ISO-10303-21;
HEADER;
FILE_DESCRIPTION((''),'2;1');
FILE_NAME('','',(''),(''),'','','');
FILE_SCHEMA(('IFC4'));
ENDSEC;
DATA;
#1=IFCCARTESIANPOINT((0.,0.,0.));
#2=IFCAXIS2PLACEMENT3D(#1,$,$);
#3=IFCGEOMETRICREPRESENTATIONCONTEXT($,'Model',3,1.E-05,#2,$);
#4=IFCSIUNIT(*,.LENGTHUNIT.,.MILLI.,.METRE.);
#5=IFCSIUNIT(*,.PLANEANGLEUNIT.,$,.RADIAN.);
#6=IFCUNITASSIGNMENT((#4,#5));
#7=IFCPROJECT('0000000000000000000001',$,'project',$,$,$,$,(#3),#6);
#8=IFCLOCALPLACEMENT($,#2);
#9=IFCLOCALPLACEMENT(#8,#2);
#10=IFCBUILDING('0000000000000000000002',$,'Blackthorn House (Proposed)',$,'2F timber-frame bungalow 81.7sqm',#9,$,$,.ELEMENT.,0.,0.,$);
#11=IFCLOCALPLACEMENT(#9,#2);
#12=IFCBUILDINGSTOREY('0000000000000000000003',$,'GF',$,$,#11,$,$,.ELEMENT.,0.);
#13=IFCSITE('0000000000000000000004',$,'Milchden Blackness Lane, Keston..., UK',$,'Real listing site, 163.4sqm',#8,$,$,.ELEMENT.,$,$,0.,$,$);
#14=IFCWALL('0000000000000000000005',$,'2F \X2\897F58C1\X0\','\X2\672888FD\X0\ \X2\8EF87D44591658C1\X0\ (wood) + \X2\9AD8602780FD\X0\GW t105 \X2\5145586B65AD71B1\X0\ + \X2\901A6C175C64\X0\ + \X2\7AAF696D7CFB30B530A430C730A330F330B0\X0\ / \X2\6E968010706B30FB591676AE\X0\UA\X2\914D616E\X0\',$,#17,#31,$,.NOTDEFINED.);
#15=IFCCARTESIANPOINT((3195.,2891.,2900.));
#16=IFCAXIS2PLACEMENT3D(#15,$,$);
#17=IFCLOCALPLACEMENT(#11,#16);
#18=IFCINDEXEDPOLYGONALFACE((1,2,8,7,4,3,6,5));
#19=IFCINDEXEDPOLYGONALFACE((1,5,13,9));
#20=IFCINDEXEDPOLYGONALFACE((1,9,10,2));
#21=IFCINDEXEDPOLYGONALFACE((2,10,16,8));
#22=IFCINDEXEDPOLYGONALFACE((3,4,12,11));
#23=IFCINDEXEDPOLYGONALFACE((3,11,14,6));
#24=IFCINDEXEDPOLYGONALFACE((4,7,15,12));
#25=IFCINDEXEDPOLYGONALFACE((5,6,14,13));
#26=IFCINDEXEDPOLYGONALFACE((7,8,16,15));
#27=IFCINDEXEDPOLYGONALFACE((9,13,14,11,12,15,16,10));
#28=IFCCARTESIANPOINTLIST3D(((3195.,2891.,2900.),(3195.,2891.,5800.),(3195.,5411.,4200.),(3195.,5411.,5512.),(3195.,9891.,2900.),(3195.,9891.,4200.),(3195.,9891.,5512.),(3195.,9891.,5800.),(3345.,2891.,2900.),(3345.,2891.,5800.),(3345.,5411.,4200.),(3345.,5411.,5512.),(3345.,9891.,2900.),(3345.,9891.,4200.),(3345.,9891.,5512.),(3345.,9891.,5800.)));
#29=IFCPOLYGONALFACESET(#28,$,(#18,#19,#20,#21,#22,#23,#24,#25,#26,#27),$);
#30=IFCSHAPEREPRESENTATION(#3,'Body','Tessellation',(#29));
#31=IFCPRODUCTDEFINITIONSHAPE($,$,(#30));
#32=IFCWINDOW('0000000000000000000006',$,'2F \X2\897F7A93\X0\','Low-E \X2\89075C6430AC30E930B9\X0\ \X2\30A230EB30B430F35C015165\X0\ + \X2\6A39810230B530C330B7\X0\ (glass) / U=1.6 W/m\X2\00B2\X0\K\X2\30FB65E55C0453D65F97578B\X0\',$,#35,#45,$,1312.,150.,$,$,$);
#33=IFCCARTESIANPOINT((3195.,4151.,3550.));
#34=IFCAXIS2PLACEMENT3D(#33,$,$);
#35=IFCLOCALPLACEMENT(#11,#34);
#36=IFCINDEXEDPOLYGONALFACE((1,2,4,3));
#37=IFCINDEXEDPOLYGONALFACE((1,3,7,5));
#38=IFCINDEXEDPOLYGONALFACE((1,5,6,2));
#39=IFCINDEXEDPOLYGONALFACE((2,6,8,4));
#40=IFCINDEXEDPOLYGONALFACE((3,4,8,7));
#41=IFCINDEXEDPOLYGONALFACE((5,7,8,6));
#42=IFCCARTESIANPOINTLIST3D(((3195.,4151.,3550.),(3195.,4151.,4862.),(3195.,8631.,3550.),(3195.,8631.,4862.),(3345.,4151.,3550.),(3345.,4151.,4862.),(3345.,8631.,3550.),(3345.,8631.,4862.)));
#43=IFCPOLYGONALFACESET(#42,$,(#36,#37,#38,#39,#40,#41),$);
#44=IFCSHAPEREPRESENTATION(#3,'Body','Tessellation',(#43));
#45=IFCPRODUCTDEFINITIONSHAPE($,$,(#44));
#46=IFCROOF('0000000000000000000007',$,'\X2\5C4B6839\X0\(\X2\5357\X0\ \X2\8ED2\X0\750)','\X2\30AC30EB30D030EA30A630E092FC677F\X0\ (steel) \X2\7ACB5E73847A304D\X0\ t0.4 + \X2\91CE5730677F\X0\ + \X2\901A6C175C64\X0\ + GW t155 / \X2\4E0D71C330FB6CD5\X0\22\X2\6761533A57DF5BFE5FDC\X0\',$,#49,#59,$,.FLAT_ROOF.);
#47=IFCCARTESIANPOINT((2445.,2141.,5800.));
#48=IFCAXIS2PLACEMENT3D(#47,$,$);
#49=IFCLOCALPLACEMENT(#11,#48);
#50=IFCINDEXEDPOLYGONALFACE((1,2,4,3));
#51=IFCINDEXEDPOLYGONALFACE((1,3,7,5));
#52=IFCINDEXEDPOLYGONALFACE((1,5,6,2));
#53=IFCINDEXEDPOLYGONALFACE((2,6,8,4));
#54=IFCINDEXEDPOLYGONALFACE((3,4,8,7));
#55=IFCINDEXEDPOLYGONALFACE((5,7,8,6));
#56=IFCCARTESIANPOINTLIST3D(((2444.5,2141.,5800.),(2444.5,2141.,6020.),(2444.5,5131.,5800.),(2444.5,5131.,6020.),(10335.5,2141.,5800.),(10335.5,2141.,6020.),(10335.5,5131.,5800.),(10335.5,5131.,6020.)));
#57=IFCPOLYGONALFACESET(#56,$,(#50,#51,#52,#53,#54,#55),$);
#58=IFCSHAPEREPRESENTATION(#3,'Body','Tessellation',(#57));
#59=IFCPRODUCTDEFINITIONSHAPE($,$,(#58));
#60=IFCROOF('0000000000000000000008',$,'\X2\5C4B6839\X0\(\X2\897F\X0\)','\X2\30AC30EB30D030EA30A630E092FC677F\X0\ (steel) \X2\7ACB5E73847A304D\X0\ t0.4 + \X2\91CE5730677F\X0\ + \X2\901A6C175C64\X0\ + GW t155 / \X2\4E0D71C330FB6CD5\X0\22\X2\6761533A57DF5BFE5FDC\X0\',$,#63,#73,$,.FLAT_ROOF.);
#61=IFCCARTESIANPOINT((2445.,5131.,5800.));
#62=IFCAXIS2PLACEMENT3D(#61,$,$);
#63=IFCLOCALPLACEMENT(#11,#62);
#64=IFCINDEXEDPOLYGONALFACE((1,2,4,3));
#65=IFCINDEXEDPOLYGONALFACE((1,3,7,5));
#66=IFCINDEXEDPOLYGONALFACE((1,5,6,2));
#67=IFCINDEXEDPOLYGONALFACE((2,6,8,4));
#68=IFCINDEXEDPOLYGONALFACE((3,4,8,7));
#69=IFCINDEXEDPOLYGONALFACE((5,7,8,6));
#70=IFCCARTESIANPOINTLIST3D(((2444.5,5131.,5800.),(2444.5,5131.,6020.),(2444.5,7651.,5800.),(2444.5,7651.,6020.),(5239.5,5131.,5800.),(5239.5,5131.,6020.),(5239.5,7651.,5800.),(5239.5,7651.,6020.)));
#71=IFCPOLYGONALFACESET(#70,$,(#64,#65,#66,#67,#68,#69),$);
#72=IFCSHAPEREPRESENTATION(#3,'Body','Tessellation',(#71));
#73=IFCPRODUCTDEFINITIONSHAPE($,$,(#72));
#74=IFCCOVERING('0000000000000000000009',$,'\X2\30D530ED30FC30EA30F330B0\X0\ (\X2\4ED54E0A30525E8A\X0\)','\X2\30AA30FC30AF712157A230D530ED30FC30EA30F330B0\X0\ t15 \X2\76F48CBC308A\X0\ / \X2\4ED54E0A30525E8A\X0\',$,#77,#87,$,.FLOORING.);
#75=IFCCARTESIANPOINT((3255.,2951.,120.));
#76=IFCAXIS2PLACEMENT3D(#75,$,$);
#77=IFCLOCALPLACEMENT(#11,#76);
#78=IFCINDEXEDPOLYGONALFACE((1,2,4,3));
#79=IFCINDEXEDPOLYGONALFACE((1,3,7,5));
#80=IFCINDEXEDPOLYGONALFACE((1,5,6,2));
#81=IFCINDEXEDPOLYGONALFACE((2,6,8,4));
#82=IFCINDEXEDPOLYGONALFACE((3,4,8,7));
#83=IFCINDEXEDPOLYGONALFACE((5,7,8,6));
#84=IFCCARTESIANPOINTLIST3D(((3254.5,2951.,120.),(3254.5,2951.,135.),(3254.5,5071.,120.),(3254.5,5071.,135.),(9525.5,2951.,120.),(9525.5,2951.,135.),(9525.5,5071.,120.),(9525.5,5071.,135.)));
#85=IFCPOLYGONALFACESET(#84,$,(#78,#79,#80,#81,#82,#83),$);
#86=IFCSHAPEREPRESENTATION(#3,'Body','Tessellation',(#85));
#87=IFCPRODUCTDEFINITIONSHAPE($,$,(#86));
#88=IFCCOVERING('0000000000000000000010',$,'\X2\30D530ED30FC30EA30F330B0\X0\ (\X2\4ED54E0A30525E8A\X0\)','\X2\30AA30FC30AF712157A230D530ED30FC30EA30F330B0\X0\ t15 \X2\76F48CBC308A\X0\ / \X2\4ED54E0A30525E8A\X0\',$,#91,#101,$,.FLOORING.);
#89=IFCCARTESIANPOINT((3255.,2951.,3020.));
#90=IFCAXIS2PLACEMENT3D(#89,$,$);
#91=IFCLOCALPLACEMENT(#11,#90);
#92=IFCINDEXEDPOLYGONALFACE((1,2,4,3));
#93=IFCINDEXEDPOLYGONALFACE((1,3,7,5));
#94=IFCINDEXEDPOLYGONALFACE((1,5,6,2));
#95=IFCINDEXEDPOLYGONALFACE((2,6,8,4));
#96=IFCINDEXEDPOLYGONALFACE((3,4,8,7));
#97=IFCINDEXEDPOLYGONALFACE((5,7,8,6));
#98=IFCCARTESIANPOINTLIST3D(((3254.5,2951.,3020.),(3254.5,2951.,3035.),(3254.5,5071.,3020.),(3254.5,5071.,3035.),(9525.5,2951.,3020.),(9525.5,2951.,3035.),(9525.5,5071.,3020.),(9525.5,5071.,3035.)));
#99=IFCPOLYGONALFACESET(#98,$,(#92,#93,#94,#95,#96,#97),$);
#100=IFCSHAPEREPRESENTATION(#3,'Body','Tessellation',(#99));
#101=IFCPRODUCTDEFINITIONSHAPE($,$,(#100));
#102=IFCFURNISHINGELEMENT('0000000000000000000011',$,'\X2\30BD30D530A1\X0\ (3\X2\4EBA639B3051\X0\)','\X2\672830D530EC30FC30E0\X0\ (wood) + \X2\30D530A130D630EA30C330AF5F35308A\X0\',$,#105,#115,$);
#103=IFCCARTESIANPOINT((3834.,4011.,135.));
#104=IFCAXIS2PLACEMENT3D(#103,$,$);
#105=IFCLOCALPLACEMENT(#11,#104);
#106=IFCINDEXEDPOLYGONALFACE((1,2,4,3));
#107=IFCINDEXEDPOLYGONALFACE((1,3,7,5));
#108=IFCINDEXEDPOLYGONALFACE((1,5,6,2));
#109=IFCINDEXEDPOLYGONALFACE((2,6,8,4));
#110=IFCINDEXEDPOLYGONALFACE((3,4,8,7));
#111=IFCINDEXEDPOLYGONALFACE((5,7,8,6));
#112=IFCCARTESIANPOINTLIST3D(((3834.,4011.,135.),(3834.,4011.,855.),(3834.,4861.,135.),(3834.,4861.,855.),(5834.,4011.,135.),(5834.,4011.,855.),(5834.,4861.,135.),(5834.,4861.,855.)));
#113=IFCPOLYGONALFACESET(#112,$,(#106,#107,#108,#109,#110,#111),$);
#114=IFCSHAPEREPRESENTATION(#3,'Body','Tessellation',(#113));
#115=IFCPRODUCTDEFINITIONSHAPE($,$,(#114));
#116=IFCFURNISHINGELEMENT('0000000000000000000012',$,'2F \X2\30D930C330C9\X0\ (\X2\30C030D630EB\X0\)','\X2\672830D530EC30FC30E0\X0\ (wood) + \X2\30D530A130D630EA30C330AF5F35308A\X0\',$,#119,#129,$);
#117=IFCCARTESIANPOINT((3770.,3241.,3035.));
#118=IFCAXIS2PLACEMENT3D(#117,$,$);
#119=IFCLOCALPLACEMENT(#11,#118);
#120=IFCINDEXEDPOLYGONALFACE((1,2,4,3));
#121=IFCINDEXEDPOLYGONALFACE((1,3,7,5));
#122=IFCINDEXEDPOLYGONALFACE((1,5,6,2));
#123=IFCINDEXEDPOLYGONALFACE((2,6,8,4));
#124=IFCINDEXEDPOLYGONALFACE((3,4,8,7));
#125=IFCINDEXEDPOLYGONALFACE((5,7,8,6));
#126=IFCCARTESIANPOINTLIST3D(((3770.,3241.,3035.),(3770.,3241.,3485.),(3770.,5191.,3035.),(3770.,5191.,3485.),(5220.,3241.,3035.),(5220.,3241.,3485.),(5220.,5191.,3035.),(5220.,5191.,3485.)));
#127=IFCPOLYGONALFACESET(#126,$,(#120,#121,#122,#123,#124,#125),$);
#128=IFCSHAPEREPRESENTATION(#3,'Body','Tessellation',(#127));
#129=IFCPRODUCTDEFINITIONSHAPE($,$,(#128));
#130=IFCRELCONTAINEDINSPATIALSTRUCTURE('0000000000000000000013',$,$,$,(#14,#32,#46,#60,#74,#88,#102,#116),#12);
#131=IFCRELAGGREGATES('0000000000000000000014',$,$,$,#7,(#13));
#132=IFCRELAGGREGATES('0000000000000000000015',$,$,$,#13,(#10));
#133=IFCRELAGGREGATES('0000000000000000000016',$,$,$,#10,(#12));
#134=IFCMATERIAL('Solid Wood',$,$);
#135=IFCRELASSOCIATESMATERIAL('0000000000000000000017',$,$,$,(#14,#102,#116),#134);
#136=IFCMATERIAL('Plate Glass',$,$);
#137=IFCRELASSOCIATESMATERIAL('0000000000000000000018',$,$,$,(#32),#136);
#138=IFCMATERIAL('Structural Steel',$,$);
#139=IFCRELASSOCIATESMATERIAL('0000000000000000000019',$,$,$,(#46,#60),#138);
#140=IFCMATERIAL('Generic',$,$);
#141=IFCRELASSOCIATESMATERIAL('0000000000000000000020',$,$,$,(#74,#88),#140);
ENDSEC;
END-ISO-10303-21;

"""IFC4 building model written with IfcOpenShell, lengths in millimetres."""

from ifc_helpers import new_model, si_unit, frame, frame_2d, origin, place, context, project, spatial, rectangle, extrude, material, element, fill, save


model = new_model("IFC4")

# Units and contexts
model_context = context("Model", 3, precision=1e-05, world=origin())
ifc_project = project(units=[si_unit("LENGTHUNIT", "METRE", prefix="MILLI"), si_unit("PLANEANGLEUNIT", "RADIAN")], contexts=[model_context])

# Site, building, storey
site_placement = place(None, origin())
site = spatial("IfcSite", under=ifc_project, at=site_placement, Name="Milchden Blackness Lane, Keston..., UK", ObjectType="Real listing site, 163.4sqm", CompositionType="ELEMENT", RefElevation=0.0)
building_placement = place(site_placement, origin())
building = spatial("IfcBuilding", under=site, at=building_placement, Name="Blackthorn House (Proposed)", ObjectType="2F timber-frame bungalow 81.7sqm", CompositionType="ELEMENT", ElevationOfRefHeight=0.0, ElevationOfTerrain=0.0)
storey_placement = place(building_placement, origin())
storey = spatial("IfcBuildingStorey", under=building, at=storey_placement, Name="GF", CompositionType="ELEMENT", Elevation=0.0)

# Shared definitions
ifc_material_1 = material(Name="Solid Wood")

# Shared definitions
ifc_material_2 = material(Name="Plate Glass")

# Wall, opening, window
wall_1_placement = place(storey_placement, frame((3195.0, 2891.0, 2900.0)))
wall_1 = element("IfcWall", 1, at=wall_1_placement, inside=storey, material=ifc_material_1, Name="2F 西壁", Description="木製 軸組外壁 (wood) + 高性能GW t105 充填断熱 + 通気層 + 窯業系サイディング / 準耐火・外皮UA配慮", PredefinedType="NOTDEFINED", context=model_context, shape_type="SweptSolid", body=[
    extrude(rectangle(XDim=150.0, YDim=7000.0, at=frame_2d((75.0, 3500.0))), frame((3195.0, 2891.0, 2900.0)), (0.0, 0.0, 1.0), 2900.0),
])
opening_1_placement = place(storey_placement, frame((3195.0, 4151.0, 3550.0)))
opening_1 = element("IfcOpeningElement", 2, at=opening_1_placement, cuts=wall_1, PredefinedType="NOTDEFINED", context=model_context, shape_type="SweptSolid", body=[
    extrude(rectangle(XDim=150.0, YDim=4480.0, at=frame_2d((75.0, 2240.0))), frame((3195.0, 4151.0, 3550.0)), (0.0, 0.0, 1.0), 1312.0),
])
window_1_placement = place(storey_placement, frame((3195.0, 4151.0, 3550.0)))
window_1 = element("IfcWindow", 3, at=window_1_placement, inside=storey, material=ifc_material_2, Name="2F 西窓", Description="Low-E 複層ガラス アルゴン封入 + 樹脂サッシ (glass) / U=1.6 W/m²K・日射取得型", OverallHeight=1312.0, OverallWidth=150.0, context=model_context, shape_type="SweptSolid", body=[
    extrude(rectangle(XDim=150.0, YDim=4480.0, at=frame_2d((75.0, 2240.0))), frame((3195.0, 4151.0, 3550.0)), (0.0, 0.0, 1.0), 1312.0),
])
fill(opening_1, window_1)

# Roofs
ifc_material_3 = material(Name="Structural Steel")
roof_1_placement = place(storey_placement, frame((2445.0, 2141.0, 5800.0)))
element("IfcRoof", 4, at=roof_1_placement, inside=storey, material=ifc_material_3, Name="屋根(南 軒750)", Description="ガルバリウム鋼板 (steel) 立平葺き t0.4 + 野地板 + 通気層 + GW t155 / 不燃・法22条区域対応", PredefinedType="FLAT_ROOF", context=model_context, shape_type="SweptSolid", body=[
    extrude(rectangle(XDim=7891.0, YDim=2990.0, at=frame_2d((3945.0, 1495.0))), frame((2445.0, 2141.0, 5800.0)), (0.0, 0.0, 1.0), 220.0),
])
roof_2_placement = place(storey_placement, frame((2445.0, 5131.0, 5800.0)))
element("IfcRoof", 5, at=roof_2_placement, inside=storey, material=ifc_material_3, Name="屋根(西)", Description="ガルバリウム鋼板 (steel) 立平葺き t0.4 + 野地板 + 通気層 + GW t155 / 不燃・法22条区域対応", PredefinedType="FLAT_ROOF", context=model_context, shape_type="SweptSolid", body=[
    extrude(rectangle(XDim=2795.0, YDim=2520.0, at=frame_2d((1397.0, 1260.0))), frame((2445.0, 5131.0, 5800.0)), (0.0, 0.0, 1.0), 220.0),
])

# Coverings
ifc_material_4 = material(Name="Generic")
covering_1_placement = place(storey_placement, frame((3255.0, 2951.0, 120.0)))
element("IfcCovering", 6, at=covering_1_placement, inside=storey, material=ifc_material_4, Name="フローリング (仕上げ床)", Description="オーク無垢フローリング t15 直貼り / 仕上げ床", PredefinedType="FLOORING", context=model_context, shape_type="SweptSolid", body=[
    extrude(rectangle(XDim=6271.0, YDim=2120.0, at=frame_2d((3135.0, 1060.0))), frame((3255.0, 2951.0, 120.0)), (0.0, 0.0, 1.0), 15.0),
])
covering_2_placement = place(storey_placement, frame((3255.0, 2951.0, 3020.0)))
element("IfcCovering", 7, at=covering_2_placement, inside=storey, material=ifc_material_4, Name="フローリング (仕上げ床)", Description="オーク無垢フローリング t15 直貼り / 仕上げ床", PredefinedType="FLOORING", context=model_context, shape_type="SweptSolid", body=[
    extrude(rectangle(XDim=6271.0, YDim=2120.0, at=frame_2d((3135.0, 1060.0))), frame((3255.0, 2951.0, 3020.0)), (0.0, 0.0, 1.0), 15.0),
])

# Furnishing elements
furnishing_1_placement = place(storey_placement, frame((3834.0, 4011.0, 135.0)))
element("IfcFurnishingElement", 8, at=furnishing_1_placement, inside=storey, material=ifc_material_1, Name="ソファ (3人掛け)", Description="木フレーム (wood) + ファブリック張り", context=model_context, shape_type="SweptSolid", body=[
    extrude(rectangle(XDim=2000.0, YDim=850.0, at=frame_2d((1000.0, 425.0))), frame((3834.0, 4011.0, 135.0)), (0.0, 0.0, 1.0), 720.0),
])
furnishing_2_placement = place(storey_placement, frame((3770.0, 3241.0, 3035.0)))
element("IfcFurnishingElement", 9, at=furnishing_2_placement, inside=storey, material=ifc_material_1, Name="2F ベッド (ダブル)", Description="木フレーム (wood) + ファブリック張り", context=model_context, shape_type="SweptSolid", body=[
    extrude(rectangle(XDim=1450.0, YDim=1950.0, at=frame_2d((725.0, 975.0))), frame((3770.0, 3241.0, 3035.0)), (0.0, 0.0, 1.0), 450.0),
])

save(model, "model.ifc")
